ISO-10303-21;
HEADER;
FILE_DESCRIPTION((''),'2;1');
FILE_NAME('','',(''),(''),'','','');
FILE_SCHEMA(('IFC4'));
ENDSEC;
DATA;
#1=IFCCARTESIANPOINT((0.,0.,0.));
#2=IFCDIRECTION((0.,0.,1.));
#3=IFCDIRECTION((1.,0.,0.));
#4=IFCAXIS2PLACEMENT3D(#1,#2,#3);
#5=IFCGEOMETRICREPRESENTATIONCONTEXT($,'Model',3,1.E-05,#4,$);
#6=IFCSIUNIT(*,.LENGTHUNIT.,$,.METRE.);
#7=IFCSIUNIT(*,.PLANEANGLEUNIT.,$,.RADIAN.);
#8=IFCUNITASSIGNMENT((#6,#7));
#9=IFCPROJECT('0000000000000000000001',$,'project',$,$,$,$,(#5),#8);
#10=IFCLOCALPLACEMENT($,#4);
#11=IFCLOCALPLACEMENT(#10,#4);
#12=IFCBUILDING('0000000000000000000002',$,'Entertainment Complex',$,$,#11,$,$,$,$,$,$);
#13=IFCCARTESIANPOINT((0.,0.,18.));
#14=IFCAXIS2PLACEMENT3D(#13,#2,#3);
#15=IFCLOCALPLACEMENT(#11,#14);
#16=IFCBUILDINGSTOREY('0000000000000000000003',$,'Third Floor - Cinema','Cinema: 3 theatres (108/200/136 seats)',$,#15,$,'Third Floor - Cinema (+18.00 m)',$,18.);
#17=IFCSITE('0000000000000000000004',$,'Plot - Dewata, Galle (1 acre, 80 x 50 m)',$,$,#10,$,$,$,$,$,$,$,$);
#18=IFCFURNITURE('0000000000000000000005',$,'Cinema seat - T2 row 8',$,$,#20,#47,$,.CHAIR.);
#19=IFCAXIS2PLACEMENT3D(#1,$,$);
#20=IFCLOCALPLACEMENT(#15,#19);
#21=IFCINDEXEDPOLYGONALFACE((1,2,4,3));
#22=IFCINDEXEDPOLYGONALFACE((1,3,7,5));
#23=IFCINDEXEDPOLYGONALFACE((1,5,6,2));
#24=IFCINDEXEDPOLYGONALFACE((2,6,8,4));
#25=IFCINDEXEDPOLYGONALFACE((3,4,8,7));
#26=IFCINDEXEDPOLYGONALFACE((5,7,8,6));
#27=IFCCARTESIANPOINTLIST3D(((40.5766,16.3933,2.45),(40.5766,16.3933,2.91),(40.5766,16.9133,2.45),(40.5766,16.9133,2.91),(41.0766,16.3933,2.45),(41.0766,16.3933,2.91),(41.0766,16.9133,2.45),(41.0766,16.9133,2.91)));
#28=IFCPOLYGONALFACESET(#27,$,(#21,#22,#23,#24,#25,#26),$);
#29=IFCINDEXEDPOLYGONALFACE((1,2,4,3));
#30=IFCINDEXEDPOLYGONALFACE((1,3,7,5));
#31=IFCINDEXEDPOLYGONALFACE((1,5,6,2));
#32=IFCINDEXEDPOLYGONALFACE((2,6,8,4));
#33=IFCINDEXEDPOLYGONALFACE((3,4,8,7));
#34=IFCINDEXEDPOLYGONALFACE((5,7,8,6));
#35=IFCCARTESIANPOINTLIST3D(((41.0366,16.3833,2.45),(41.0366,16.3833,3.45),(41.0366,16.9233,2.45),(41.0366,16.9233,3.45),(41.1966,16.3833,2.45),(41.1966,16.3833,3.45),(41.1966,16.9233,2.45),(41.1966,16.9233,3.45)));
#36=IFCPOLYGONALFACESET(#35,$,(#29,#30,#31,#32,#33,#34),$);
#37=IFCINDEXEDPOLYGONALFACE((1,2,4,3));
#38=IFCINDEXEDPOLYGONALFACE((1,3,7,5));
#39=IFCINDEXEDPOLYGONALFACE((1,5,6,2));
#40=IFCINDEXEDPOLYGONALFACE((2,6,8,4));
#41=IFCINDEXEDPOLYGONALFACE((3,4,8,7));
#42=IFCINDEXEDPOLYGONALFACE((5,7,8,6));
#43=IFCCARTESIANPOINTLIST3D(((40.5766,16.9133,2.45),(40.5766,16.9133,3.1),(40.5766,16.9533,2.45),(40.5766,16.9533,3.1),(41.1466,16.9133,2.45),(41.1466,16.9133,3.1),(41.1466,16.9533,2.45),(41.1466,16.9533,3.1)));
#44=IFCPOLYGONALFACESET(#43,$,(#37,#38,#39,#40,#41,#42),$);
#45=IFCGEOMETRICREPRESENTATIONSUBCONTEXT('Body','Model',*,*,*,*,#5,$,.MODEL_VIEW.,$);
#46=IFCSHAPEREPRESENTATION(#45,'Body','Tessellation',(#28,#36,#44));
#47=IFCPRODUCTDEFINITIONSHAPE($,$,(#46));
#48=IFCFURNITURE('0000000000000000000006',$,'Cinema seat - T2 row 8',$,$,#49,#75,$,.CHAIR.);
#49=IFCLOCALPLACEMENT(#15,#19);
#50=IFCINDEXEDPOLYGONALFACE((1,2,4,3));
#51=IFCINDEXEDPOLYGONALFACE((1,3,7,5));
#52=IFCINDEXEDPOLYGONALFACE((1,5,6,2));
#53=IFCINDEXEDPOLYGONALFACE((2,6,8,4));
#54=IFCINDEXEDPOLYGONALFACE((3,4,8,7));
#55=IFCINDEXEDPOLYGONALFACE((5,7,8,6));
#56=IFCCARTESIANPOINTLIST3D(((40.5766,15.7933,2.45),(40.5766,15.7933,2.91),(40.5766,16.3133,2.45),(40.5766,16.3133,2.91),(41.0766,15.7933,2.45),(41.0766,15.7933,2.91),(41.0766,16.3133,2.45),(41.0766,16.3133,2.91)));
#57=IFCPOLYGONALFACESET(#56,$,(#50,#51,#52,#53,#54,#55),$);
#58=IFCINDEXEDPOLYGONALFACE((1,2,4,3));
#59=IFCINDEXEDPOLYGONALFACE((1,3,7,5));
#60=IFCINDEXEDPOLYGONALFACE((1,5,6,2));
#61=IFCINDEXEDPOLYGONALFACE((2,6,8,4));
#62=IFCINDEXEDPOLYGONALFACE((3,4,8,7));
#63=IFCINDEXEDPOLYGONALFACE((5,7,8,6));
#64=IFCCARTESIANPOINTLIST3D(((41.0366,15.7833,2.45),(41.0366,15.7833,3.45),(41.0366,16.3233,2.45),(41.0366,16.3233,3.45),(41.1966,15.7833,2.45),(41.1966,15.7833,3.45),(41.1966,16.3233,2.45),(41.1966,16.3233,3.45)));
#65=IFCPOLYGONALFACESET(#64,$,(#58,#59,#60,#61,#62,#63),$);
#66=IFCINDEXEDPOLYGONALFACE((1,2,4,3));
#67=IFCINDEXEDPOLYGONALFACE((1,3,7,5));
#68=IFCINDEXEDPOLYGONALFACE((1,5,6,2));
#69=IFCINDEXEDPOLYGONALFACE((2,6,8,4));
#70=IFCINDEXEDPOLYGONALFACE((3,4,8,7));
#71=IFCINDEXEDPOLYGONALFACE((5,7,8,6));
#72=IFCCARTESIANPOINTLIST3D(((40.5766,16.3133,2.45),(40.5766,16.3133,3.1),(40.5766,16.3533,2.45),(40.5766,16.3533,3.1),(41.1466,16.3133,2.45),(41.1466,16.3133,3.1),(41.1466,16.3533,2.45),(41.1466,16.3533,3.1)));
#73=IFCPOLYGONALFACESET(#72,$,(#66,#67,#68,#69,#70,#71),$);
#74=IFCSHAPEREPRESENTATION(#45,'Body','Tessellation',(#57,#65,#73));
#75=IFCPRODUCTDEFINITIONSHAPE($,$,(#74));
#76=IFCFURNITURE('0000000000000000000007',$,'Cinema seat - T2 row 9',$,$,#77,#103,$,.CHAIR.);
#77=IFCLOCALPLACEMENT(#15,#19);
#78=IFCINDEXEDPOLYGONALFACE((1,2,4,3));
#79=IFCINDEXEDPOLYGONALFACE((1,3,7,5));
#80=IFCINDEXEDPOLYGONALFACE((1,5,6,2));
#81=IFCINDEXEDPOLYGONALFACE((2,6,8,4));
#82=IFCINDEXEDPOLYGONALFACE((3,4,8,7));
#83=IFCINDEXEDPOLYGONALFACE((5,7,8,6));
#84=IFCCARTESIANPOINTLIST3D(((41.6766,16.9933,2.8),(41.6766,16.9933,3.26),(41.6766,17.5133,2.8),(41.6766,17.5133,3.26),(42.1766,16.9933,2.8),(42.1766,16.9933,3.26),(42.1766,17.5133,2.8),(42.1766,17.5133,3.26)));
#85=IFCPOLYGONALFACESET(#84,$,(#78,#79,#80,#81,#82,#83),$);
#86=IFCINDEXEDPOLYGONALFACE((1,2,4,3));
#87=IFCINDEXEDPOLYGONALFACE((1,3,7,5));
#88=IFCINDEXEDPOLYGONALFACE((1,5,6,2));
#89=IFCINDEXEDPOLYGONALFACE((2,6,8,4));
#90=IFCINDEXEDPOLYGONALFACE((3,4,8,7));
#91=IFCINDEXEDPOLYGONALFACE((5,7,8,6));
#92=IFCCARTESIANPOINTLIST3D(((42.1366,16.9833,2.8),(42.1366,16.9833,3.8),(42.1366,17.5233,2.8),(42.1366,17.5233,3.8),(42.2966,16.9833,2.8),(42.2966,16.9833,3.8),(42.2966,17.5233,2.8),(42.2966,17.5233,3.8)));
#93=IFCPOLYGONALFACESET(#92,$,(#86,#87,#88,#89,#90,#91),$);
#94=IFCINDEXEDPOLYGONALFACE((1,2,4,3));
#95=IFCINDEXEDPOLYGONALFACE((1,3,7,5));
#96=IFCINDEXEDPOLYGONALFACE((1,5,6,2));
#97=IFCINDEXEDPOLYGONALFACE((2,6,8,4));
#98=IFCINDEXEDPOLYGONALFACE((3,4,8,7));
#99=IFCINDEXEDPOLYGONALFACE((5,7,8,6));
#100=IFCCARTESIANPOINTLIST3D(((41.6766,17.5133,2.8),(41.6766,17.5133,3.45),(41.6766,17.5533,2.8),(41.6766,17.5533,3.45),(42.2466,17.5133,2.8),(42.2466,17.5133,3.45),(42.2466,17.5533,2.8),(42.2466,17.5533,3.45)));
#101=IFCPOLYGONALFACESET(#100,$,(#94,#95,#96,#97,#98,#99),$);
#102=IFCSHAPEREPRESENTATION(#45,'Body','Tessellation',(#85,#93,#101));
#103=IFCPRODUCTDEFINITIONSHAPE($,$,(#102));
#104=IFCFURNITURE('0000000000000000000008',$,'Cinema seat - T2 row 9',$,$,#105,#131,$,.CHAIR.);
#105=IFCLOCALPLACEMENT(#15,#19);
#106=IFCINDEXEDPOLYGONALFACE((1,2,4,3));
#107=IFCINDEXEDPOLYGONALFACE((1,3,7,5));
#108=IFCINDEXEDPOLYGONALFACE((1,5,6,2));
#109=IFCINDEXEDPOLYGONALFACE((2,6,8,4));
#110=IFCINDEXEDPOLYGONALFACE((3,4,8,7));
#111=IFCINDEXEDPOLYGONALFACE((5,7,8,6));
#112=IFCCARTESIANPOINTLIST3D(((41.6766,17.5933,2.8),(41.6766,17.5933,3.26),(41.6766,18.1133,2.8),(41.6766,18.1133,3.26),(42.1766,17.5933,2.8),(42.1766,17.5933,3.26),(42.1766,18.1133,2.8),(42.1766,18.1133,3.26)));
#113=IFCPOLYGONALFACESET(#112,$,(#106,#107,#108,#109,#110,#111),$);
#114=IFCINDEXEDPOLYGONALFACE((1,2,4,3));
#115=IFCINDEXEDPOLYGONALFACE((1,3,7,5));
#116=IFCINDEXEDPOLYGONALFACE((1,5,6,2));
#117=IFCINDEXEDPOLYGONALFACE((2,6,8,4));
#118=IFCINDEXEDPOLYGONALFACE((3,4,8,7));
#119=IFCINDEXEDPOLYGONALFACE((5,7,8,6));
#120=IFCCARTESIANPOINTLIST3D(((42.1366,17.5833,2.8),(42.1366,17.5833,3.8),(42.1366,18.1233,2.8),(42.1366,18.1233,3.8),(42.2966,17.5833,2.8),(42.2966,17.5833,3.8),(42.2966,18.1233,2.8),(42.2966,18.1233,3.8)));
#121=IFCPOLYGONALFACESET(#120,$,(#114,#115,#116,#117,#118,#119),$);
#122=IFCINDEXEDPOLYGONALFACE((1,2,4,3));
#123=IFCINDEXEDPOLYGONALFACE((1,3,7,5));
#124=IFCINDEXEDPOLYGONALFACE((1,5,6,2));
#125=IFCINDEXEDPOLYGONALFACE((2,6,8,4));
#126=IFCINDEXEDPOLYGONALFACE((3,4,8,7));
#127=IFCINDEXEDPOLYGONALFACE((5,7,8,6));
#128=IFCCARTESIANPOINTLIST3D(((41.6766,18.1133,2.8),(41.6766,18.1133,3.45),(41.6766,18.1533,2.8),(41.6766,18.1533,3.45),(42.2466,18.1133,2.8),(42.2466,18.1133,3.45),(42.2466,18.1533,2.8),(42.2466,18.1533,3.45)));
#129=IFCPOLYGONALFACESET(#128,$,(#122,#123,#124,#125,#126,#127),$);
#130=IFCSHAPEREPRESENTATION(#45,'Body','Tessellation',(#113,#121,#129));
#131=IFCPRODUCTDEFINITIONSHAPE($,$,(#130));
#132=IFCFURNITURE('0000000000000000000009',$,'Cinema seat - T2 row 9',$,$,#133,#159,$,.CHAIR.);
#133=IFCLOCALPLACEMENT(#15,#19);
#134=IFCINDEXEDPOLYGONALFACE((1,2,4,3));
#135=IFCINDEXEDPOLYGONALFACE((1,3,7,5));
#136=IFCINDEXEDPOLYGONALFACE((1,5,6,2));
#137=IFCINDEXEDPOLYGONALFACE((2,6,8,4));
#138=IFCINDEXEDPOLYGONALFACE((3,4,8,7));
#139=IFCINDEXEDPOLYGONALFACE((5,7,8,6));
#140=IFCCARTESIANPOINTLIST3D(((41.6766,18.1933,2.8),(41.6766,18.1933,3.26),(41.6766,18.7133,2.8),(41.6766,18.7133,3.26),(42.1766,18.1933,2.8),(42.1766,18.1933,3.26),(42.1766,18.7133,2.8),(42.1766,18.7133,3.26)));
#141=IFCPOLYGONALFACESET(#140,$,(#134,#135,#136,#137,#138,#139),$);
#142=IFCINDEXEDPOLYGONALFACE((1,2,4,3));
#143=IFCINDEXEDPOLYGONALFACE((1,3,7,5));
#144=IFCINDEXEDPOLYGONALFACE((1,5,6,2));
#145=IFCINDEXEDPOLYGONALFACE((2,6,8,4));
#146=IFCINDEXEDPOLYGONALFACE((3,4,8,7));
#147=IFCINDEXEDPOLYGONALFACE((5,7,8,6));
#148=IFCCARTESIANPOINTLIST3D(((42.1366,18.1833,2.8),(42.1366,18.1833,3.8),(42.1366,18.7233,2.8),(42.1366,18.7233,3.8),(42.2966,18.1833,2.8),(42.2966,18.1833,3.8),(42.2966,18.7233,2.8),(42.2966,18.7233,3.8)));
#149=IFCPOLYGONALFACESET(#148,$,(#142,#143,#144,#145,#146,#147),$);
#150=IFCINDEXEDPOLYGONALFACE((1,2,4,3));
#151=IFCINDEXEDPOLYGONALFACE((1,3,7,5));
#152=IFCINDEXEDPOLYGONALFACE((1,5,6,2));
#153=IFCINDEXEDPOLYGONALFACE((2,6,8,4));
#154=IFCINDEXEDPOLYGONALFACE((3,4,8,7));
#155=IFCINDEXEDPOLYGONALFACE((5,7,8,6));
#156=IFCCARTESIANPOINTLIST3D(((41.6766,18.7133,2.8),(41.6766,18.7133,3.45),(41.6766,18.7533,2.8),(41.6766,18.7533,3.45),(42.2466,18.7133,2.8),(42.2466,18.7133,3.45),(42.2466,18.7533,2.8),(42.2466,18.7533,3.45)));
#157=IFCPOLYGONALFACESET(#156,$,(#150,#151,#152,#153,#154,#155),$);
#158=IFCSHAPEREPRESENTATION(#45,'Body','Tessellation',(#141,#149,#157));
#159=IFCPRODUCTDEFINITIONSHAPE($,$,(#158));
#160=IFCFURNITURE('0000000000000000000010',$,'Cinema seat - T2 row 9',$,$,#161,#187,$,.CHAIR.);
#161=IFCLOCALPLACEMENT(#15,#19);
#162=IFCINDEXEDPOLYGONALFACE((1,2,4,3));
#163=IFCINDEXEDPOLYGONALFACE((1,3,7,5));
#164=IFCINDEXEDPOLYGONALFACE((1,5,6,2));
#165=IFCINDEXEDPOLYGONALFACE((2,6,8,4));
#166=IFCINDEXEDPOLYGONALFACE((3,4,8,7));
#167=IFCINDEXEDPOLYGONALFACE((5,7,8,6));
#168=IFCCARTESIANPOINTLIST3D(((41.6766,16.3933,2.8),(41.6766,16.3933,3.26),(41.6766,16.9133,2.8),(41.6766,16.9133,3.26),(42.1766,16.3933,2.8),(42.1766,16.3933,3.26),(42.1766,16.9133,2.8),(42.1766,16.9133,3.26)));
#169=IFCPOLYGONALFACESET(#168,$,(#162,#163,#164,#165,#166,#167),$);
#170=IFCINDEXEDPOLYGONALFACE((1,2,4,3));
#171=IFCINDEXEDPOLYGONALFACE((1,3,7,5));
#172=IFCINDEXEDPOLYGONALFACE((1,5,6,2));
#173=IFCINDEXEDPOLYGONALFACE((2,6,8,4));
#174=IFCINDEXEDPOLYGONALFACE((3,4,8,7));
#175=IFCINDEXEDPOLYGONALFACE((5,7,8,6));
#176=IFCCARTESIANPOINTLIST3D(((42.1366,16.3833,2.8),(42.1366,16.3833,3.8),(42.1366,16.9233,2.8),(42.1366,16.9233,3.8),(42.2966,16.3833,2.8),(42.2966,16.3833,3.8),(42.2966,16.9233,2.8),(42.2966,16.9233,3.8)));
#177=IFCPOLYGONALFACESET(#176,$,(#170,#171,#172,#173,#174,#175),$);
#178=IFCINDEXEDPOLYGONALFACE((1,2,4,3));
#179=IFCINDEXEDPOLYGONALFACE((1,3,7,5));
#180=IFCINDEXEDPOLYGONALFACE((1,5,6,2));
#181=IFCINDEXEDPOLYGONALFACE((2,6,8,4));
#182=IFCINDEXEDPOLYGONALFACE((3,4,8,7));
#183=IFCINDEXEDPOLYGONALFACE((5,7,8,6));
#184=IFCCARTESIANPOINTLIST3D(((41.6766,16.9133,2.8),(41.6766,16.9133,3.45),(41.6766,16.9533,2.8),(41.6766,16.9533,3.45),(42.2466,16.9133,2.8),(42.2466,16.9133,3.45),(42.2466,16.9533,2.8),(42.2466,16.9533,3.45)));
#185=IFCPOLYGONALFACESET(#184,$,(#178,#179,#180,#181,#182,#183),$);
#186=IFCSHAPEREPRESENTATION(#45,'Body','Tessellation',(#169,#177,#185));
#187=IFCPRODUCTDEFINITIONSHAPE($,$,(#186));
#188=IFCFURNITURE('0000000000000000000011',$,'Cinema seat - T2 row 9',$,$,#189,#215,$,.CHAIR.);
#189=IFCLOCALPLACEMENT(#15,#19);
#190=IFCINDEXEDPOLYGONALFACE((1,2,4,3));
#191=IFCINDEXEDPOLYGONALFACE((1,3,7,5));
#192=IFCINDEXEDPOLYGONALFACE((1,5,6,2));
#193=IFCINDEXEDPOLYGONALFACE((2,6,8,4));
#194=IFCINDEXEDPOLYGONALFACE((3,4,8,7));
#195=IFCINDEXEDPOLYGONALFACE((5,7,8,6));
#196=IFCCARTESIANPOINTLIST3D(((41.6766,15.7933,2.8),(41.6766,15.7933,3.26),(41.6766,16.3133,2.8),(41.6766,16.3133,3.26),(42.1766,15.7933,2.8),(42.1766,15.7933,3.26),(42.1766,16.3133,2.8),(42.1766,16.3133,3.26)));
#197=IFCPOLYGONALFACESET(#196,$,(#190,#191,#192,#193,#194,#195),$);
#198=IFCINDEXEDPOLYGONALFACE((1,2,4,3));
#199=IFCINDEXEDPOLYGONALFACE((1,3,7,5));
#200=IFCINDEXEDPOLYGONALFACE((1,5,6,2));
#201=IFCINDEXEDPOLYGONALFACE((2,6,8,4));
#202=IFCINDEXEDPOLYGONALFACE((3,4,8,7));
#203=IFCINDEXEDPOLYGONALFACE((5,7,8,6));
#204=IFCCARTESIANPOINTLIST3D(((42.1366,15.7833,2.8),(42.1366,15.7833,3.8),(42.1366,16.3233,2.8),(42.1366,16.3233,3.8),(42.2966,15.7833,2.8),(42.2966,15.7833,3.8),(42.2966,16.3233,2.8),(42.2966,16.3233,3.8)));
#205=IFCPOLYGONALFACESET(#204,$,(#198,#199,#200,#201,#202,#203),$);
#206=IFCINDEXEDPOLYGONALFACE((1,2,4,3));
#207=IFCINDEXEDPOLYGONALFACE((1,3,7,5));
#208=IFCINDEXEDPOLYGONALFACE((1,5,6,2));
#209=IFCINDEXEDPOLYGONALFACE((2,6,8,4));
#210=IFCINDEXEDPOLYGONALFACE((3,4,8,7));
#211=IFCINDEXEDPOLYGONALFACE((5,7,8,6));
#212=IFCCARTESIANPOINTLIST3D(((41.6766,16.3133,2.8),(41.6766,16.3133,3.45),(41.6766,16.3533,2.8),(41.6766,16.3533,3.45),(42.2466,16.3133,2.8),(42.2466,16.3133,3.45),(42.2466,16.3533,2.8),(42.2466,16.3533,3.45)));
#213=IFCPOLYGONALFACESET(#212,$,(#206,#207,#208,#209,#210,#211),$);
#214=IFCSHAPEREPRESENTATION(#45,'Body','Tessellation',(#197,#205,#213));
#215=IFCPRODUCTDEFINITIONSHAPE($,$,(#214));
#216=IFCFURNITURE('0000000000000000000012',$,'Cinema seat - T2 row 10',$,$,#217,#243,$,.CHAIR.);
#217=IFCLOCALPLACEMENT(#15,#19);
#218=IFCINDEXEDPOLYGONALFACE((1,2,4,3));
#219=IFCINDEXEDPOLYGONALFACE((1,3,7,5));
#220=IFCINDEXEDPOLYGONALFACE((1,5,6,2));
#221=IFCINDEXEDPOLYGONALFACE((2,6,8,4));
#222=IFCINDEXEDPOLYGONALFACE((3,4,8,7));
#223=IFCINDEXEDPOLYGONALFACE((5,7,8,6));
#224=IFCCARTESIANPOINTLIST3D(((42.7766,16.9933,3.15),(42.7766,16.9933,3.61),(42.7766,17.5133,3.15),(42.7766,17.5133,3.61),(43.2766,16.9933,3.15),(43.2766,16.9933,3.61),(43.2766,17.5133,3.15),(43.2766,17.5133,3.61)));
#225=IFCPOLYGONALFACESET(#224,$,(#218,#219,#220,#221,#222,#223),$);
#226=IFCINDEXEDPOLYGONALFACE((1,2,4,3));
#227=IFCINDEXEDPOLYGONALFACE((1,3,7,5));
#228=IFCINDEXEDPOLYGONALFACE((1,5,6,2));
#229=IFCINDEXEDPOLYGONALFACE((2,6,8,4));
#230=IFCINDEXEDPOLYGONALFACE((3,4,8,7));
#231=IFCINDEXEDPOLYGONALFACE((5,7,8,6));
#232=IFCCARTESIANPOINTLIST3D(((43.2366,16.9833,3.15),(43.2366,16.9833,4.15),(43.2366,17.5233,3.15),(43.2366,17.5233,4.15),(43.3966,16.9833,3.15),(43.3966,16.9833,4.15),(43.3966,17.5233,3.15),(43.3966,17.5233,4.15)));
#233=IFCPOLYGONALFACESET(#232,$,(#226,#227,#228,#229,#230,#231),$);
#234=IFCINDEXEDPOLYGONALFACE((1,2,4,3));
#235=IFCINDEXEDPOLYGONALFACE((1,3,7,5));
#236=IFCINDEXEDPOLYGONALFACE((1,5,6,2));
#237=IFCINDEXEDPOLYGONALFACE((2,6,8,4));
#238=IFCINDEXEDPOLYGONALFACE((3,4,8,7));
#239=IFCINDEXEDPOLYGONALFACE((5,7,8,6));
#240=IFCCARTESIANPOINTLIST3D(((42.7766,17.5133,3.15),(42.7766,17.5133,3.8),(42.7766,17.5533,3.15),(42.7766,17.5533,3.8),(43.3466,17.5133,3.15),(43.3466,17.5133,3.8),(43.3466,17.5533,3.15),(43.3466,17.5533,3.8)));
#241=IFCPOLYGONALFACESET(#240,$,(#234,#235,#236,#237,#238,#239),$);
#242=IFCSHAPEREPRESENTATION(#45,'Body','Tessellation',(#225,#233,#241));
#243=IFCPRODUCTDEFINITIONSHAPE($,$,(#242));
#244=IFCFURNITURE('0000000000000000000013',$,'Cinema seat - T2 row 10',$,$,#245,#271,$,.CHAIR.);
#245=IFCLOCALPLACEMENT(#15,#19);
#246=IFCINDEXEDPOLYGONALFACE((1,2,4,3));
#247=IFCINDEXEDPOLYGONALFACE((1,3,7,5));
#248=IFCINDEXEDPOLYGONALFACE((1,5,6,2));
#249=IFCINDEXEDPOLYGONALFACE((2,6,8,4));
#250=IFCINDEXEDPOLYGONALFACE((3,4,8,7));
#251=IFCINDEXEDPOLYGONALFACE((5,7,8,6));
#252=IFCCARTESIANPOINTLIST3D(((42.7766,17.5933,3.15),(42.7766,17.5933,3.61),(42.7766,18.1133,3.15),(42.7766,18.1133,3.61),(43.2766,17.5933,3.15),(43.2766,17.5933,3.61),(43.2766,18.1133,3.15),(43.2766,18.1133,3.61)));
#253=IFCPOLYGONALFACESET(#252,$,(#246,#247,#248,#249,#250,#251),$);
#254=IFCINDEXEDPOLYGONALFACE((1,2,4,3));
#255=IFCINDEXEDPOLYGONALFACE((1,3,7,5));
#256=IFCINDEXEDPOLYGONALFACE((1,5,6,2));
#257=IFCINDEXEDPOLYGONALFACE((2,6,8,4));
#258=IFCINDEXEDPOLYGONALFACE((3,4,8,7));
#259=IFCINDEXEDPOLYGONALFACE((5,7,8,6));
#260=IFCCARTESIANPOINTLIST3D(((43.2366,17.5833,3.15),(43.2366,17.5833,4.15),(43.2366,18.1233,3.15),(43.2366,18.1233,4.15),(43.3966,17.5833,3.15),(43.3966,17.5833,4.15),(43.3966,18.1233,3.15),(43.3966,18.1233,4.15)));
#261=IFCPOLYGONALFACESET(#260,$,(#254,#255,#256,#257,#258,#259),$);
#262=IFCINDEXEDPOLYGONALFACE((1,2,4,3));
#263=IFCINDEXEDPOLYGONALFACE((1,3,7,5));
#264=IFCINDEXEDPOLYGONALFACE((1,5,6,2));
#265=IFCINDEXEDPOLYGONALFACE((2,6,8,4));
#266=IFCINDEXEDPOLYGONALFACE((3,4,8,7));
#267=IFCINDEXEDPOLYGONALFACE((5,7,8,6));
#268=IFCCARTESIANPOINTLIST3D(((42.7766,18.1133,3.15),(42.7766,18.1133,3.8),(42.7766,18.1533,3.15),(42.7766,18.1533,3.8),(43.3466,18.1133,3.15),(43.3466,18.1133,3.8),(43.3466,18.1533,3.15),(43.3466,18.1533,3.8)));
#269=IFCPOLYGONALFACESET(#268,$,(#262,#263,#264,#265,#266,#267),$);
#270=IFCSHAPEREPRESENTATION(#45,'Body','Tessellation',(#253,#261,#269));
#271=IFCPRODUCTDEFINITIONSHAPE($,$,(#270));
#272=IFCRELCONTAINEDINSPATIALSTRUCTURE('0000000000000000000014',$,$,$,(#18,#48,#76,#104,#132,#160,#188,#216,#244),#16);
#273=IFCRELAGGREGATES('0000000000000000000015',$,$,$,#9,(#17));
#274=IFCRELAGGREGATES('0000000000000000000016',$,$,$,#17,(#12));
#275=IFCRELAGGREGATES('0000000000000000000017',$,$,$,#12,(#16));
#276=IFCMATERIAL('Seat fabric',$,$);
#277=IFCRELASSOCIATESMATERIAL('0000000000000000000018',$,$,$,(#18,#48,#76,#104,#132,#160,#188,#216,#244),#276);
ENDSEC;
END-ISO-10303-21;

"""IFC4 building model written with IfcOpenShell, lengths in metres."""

from ifc_helpers import new_model, si_unit, frame, origin_with_axes, place, context, subcontext, project, spatial, polyline, outline, extrude, material, element, save


model = new_model("IFC4")

# Units and contexts
model_context = context("Model", 3, precision=1e-05, world=origin_with_axes())
body_context = subcontext(model_context, "Body", "Model", "MODEL_VIEW")
ifc_project = project(units=[si_unit("LENGTHUNIT", "METRE"), si_unit("PLANEANGLEUNIT", "RADIAN")], contexts=[model_context])

# Site, building, storey
site_placement = place(None, origin_with_axes())
site = spatial("IfcSite", under=ifc_project, at=site_placement, Name="Plot - Dewata, Galle (1 acre, 80 x 50 m)")
building_placement = place(site_placement, origin_with_axes())
building = spatial("IfcBuilding", under=site, at=building_placement, Name="Entertainment Complex")
storey_placement = place(building_placement, frame((0.0, 0.0, 18.0), z_axis=(0.0, 0.0, 1.0), x_axis=(1.0, 0.0, 0.0)))
storey = spatial("IfcBuildingStorey", under=building, at=storey_placement, Name="Third Floor - Cinema", Description="Cinema: 3 theatres (108/200/136 seats)", LongName="Third Floor - Cinema (+18.00 m)", Elevation=18.0)

# Furniture
ifc_material_1 = material(Name="Seat fabric")
for number, where, z_axis, x_axis, name in (
    (1, (41.1966, 16.6533, 2.45), (0.0, 0.0, 1.0), (1.0, 0.0, 0.0), "Cinema seat - T2 row 8"),
    (2, (41.1966, 16.0533, 2.45), (0.0, 0.0, 1.0), (1.0, 0.0, 0.0), "Cinema seat - T2 row 8"),
    (3, (42.2966, 17.2533, 2.8), (0.0, 0.0, 1.0), (1.0, 0.0, 0.0), "Cinema seat - T2 row 9"),
    (4, (42.2966, 17.8533, 2.8), (0.0, 0.0, 1.0), (1.0, 0.0, 0.0), "Cinema seat - T2 row 9"),
    (5, (42.2966, 18.4533, 2.8), (0.0, 0.0, 1.0), (1.0, 0.0, 0.0), "Cinema seat - T2 row 9"),
    (6, (42.2966, 16.6533, 2.8), (0.0, 0.0, 1.0), (1.0, 0.0, 0.0), "Cinema seat - T2 row 9"),
    (7, (42.2966, 16.0533, 2.8), (0.0, 0.0, 1.0), (1.0, 0.0, 0.0), "Cinema seat - T2 row 9"),
    (8, (43.3966, 17.2533, 3.15), (0.0, 0.0, 1.0), (1.0, 0.0, 0.0), "Cinema seat - T2 row 10"),
    (9, (43.3966, 17.8533, 3.15), (0.0, 0.0, 1.0), (1.0, 0.0, 0.0), "Cinema seat - T2 row 10"),
):
    element("IfcFurniture", number, at=place(storey_placement, frame(where, z_axis=z_axis, x_axis=x_axis)), inside=storey, material=ifc_material_1, Name=name, PredefinedType="CHAIR", context=body_context, shape_type="SweptSolid", body=[
        extrude(outline(polyline([(-0.62, -0.26), (-0.12, -0.26), (-0.12, 0.26), (-0.62, 0.26), (-0.62, -0.26)])), origin_with_axes(), (0.0, 0.0, 1.0), 0.46),
        extrude(outline(polyline([(-0.16, -0.27), (0.0, -0.27), (0.0, 0.27), (-0.16, 0.27), (-0.16, -0.27)])), origin_with_axes(), (0.0, 0.0, 1.0), 1.0),
        extrude(outline(polyline([(-0.62, 0.26), (-0.05, 0.26), (-0.05, 0.3), (-0.62, 0.3), (-0.62, 0.26)])), origin_with_axes(), (0.0, 0.0, 1.0), 0.65),
    ])

save(model, "model.ifc")
